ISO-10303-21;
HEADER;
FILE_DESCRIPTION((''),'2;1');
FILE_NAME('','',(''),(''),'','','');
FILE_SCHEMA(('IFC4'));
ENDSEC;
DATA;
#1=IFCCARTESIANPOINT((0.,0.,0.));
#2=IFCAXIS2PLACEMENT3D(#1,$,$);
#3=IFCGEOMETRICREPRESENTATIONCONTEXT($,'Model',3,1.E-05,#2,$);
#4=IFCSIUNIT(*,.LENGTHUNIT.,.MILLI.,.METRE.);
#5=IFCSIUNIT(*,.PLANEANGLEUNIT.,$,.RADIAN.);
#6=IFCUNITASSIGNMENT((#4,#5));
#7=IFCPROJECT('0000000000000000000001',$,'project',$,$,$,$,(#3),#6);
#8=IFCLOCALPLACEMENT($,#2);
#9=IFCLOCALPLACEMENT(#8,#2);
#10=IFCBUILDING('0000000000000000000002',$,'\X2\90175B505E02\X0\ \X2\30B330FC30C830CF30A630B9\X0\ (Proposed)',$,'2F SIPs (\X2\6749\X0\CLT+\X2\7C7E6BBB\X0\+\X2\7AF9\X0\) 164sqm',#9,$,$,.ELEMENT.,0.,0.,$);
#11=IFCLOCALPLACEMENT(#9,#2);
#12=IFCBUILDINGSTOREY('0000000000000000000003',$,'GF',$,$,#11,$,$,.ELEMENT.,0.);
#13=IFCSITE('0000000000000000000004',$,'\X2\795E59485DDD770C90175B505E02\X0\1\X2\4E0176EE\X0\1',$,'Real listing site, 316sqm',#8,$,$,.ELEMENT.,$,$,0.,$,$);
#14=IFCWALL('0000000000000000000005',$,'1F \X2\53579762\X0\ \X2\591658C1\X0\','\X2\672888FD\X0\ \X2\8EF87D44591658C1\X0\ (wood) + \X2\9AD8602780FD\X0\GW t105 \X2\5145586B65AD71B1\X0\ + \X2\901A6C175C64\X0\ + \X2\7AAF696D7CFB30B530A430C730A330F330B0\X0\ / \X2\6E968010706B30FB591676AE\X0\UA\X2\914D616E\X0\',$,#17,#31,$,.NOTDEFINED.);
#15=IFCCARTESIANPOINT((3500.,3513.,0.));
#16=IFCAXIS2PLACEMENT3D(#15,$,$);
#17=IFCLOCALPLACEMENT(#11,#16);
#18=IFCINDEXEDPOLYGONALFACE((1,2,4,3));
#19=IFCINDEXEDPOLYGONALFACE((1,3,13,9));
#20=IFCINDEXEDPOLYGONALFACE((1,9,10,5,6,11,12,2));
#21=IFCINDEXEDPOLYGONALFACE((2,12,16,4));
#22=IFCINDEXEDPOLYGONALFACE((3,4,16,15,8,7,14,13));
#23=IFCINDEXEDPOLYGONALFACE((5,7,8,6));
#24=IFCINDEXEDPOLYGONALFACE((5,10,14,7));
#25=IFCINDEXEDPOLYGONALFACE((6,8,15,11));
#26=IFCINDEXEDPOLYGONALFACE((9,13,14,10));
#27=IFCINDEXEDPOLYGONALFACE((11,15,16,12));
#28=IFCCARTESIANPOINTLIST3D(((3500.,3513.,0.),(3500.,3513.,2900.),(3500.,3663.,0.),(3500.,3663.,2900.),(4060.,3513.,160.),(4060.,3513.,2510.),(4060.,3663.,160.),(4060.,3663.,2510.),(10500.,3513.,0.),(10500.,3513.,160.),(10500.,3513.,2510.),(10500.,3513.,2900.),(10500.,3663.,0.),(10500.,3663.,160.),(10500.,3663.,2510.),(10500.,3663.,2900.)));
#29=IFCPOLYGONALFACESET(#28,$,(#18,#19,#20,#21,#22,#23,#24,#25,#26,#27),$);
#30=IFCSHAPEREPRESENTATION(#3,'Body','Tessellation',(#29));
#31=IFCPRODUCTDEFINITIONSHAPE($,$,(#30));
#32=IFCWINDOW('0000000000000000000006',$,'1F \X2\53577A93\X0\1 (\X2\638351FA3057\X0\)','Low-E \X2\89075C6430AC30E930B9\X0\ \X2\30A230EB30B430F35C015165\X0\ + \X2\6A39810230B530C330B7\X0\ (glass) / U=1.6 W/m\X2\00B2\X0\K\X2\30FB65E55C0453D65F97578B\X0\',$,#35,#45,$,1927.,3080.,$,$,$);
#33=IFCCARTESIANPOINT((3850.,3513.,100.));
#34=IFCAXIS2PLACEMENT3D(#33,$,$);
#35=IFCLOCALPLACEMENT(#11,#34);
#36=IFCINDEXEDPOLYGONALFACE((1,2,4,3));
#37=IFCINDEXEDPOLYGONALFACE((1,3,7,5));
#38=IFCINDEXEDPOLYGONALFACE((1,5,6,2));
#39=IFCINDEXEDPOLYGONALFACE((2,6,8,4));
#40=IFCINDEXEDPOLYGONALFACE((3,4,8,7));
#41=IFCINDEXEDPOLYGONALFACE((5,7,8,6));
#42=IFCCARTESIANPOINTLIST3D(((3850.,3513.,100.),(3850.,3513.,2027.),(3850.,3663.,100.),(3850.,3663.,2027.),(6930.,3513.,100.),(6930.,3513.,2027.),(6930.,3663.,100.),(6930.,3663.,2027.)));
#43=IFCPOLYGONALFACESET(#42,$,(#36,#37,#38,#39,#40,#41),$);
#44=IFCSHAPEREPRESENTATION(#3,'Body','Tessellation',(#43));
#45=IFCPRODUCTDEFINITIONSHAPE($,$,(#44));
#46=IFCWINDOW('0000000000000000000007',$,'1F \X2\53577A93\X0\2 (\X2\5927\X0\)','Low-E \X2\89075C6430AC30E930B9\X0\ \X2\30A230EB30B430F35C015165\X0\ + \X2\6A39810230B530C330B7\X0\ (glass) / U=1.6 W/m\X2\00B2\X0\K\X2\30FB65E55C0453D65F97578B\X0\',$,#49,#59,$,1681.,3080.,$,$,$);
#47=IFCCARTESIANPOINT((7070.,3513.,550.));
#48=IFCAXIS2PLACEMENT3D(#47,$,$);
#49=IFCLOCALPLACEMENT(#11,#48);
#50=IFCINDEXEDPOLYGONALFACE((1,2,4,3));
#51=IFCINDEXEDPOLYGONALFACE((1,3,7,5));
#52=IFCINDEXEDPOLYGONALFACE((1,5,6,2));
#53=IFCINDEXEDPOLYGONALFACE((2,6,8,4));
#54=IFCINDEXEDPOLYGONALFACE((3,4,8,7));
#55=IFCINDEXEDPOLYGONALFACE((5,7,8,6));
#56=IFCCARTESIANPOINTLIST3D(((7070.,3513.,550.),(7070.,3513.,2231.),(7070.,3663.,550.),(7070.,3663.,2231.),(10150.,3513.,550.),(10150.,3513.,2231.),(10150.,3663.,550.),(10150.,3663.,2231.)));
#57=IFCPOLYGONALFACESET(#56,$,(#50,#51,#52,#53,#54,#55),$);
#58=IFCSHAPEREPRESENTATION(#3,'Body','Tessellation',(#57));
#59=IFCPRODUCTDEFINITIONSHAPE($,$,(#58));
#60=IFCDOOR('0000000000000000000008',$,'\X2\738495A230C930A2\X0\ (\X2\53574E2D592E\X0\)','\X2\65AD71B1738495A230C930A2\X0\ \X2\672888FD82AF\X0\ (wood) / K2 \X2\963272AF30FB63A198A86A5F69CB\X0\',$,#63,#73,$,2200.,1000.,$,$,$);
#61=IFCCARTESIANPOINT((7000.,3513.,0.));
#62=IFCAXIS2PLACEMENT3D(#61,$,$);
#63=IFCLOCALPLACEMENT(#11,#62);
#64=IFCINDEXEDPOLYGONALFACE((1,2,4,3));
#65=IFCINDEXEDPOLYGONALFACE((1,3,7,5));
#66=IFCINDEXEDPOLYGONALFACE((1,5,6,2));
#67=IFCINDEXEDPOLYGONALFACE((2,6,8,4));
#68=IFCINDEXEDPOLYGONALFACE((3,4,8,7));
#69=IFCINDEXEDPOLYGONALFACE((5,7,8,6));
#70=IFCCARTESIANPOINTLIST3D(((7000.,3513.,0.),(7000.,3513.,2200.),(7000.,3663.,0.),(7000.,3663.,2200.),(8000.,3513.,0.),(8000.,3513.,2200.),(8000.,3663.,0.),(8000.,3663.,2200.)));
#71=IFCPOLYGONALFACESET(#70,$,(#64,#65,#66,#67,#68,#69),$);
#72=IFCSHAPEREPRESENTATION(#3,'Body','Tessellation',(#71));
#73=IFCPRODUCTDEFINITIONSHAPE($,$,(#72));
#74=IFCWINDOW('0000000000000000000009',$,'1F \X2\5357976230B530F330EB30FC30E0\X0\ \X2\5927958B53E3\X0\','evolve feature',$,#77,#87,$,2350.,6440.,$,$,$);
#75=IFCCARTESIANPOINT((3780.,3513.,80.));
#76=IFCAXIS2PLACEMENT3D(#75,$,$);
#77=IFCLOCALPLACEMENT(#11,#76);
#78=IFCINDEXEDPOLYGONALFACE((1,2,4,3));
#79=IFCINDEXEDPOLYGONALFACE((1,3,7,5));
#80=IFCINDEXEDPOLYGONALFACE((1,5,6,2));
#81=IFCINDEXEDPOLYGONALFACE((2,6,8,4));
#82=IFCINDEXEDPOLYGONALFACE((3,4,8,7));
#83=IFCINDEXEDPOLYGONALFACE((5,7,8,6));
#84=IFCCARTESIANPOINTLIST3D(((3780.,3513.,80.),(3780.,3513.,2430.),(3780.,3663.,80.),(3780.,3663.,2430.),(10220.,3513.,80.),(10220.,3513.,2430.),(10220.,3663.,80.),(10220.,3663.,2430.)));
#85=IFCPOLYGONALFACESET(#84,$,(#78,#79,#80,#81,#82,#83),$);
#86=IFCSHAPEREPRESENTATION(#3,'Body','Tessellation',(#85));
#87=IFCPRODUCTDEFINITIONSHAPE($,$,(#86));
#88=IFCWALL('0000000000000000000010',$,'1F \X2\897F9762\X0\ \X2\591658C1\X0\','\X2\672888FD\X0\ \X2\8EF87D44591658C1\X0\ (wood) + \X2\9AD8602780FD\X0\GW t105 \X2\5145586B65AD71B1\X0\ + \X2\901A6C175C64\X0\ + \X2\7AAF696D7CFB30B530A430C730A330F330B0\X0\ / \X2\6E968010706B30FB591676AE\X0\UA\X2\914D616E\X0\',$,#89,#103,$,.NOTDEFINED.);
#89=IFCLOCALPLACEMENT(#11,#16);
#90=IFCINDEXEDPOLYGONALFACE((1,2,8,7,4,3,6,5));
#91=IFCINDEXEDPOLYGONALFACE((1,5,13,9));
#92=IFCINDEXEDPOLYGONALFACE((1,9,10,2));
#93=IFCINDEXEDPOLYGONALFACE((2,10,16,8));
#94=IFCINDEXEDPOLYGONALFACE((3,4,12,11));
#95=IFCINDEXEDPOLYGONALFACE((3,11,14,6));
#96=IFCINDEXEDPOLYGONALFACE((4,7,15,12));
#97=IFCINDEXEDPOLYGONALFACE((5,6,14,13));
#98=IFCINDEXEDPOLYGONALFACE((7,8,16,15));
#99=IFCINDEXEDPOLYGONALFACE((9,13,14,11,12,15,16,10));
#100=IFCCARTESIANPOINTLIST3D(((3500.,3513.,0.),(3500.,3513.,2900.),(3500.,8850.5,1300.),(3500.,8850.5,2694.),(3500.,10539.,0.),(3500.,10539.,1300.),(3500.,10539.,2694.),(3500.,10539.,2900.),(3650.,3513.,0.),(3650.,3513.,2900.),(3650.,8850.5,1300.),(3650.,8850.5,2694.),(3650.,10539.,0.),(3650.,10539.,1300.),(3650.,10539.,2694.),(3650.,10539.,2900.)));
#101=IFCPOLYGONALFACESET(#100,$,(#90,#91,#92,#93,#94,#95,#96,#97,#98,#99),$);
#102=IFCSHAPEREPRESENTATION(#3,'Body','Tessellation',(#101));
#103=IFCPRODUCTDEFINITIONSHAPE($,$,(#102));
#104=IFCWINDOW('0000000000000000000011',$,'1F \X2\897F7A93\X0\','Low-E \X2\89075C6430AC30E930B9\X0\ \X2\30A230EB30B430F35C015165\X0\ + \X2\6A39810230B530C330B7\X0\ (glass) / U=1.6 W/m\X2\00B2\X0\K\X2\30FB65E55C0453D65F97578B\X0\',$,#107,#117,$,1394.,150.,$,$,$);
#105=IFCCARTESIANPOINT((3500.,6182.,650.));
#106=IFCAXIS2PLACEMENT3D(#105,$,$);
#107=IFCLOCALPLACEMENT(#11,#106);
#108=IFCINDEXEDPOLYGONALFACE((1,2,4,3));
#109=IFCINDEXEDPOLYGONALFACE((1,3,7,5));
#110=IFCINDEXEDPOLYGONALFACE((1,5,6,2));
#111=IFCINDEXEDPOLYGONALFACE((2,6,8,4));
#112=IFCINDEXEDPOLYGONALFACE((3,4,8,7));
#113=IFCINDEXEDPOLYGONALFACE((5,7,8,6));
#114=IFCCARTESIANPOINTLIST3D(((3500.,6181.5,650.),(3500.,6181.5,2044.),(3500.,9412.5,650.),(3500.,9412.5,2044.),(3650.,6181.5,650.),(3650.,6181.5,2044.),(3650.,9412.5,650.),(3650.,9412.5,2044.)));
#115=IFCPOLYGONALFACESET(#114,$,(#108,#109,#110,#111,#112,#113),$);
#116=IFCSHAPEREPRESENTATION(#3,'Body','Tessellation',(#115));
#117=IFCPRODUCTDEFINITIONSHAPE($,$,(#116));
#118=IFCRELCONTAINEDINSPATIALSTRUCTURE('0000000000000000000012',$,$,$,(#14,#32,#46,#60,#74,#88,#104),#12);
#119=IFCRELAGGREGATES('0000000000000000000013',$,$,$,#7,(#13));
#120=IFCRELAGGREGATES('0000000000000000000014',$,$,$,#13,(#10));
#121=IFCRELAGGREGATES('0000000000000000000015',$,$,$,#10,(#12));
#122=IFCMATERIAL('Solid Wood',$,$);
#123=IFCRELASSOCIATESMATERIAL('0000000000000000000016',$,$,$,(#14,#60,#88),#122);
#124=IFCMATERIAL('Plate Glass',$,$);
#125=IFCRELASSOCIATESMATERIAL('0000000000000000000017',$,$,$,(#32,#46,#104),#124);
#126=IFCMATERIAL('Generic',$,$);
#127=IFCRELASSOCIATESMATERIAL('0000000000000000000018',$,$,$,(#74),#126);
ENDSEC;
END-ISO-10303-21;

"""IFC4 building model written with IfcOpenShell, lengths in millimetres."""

from ifc_helpers import new_model, si_unit, frame, frame_2d, origin, place, context, project, spatial, rectangle, extrude, material, element, fill, save


model = new_model("IFC4")

# Units and contexts
model_context = context("Model", 3, precision=1e-05, world=origin())
ifc_project = project(units=[si_unit("LENGTHUNIT", "METRE", prefix="MILLI"), si_unit("PLANEANGLEUNIT", "RADIAN")], contexts=[model_context])

# Site, building, storey
site_placement = place(None, origin())
site = spatial("IfcSite", under=ifc_project, at=site_placement, Name="神奈川県逗子市1丁目1", ObjectType="Real listing site, 316sqm", CompositionType="ELEMENT", RefElevation=0.0)
building_placement = place(site_placement, origin())
building = spatial("IfcBuilding", under=site, at=building_placement, Name="逗子市 コートハウス (Proposed)", ObjectType="2F SIPs (杉CLT+籾殻+竹) 164sqm", CompositionType="ELEMENT", ElevationOfRefHeight=0.0, ElevationOfTerrain=0.0)
storey_placement = place(building_placement, origin())
storey = spatial("IfcBuildingStorey", under=building, at=storey_placement, Name="GF", CompositionType="ELEMENT", Elevation=0.0)

# Shared definitions
ifc_material_1 = material(Name="Solid Wood")
ifc_material_2 = material(Name="Generic")

# Wall, openings, windows, door
wall_1_placement = place(storey_placement, frame((3500.0, 3513.0, 0.0)))
wall_1 = element("IfcWall", 1, at=wall_1_placement, inside=storey, material=ifc_material_1, Name="1F 南面 外壁", Description="木製 軸組外壁 (wood) + 高性能GW t105 充填断熱 + 通気層 + 窯業系サイディング / 準耐火・外皮UA配慮", PredefinedType="NOTDEFINED", context=model_context, shape_type="SweptSolid", body=[
    extrude(rectangle(XDim=7000.0, YDim=150.0, at=frame_2d((3500.0, 75.0))), frame((3500.0, 3513.0, 0.0)), (0.0, 0.0, 1.0), 2900.0),
])
opening_1_placement = place(storey_placement, frame((3850.0, 3513.0, 100.0)))
opening_1 = element("IfcOpeningElement", 2, at=opening_1_placement, cuts=wall_1, PredefinedType="NOTDEFINED", context=model_context, shape_type="SweptSolid", body=[
    extrude(rectangle(XDim=3080.0, YDim=150.0, at=frame_2d((1540.0, 75.0))), frame((3850.0, 3513.0, 100.0)), (0.0, 0.0, 1.0), 1927.0),
])
opening_2_placement = place(storey_placement, frame((7070.0, 3513.0, 550.0)))
opening_2 = element("IfcOpeningElement", 3, at=opening_2_placement, cuts=wall_1, PredefinedType="NOTDEFINED", context=model_context, shape_type="SweptSolid", body=[
    extrude(rectangle(XDim=3080.0, YDim=150.0, at=frame_2d((1540.0, 75.0))), frame((7070.0, 3513.0, 550.0)), (0.0, 0.0, 1.0), 1681.0),
])
opening_3_placement = place(storey_placement, frame((7000.0, 3513.0, 0.0)))
opening_3 = element("IfcOpeningElement", 4, at=opening_3_placement, cuts=wall_1, PredefinedType="NOTDEFINED", context=model_context, shape_type="SweptSolid", body=[
    extrude(rectangle(XDim=1000.0, YDim=150.0, at=frame_2d((500.0, 75.0))), frame((7000.0, 3513.0, 0.0)), (0.0, 0.0, 1.0), 2200.0),
])
opening_4_placement = place(storey_placement, frame((3780.0, 3513.0, 80.0)))
opening_4 = element("IfcOpeningElement", 5, at=opening_4_placement, cuts=wall_1, PredefinedType="NOTDEFINED", context=model_context, shape_type="SweptSolid", body=[
    extrude(rectangle(XDim=6440.0, YDim=150.0, at=frame_2d((3220.0, 75.0))), frame((3780.0, 3513.0, 80.0)), (0.0, 0.0, 1.0), 2350.0),
])
ifc_material_3 = material(Name="Plate Glass")
window_1_placement = place(storey_placement, frame((3850.0, 3513.0, 100.0)))
window_1 = element("IfcWindow", 6, at=window_1_placement, inside=storey, material=ifc_material_3, Name="1F 南窓1 (掃出し)", Description="Low-E 複層ガラス アルゴン封入 + 樹脂サッシ (glass) / U=1.6 W/m²K・日射取得型", OverallHeight=1927.0, OverallWidth=3080.0, context=model_context, shape_type="SweptSolid", body=[
    extrude(rectangle(XDim=3080.0, YDim=150.0, at=frame_2d((1540.0, 75.0))), frame((3850.0, 3513.0, 100.0)), (0.0, 0.0, 1.0), 1927.0),
])
fill(opening_1, window_1)
window_2_placement = place(storey_placement, frame((7070.0, 3513.0, 550.0)))
window_2 = element("IfcWindow", 7, at=window_2_placement, inside=storey, material=ifc_material_3, Name="1F 南窓2 (大)", Description="Low-E 複層ガラス アルゴン封入 + 樹脂サッシ (glass) / U=1.6 W/m²K・日射取得型", OverallHeight=1681.0, OverallWidth=3080.0, context=model_context, shape_type="SweptSolid", body=[
    extrude(rectangle(XDim=3080.0, YDim=150.0, at=frame_2d((1540.0, 75.0))), frame((7070.0, 3513.0, 550.0)), (0.0, 0.0, 1.0), 1681.0),
])
fill(opening_2, window_2)
door_placement = place(storey_placement, frame((7000.0, 3513.0, 0.0)))
door = element("IfcDoor", 8, at=door_placement, inside=storey, material=ifc_material_1, Name="玄関ドア (南中央)", Description="断熱玄関ドア 木製芯 (wood) / K2 防犯・採風機構", OverallHeight=2200.0, OverallWidth=1000.0, context=model_context, shape_type="SweptSolid", body=[
    extrude(rectangle(XDim=1000.0, YDim=150.0, at=frame_2d((500.0, 75.0))), frame((7000.0, 3513.0, 0.0)), (0.0, 0.0, 1.0), 2200.0),
])
fill(opening_3, door)
window_3_placement = place(storey_placement, frame((3780.0, 3513.0, 80.0)))
window_3 = element("IfcWindow", 9, at=window_3_placement, inside=storey, material=ifc_material_2, Name="1F 南面サンルーム 大開口", Description="evolve feature", OverallHeight=2350.0, OverallWidth=6440.0, context=model_context, shape_type="SweptSolid", body=[
    extrude(rectangle(XDim=6440.0, YDim=150.0, at=frame_2d((3220.0, 75.0))), frame((3780.0, 3513.0, 80.0)), (0.0, 0.0, 1.0), 2350.0),
])
fill(opening_4, window_3)

# Wall, opening, window
wall_2_placement = place(storey_placement, frame((3500.0, 3513.0, 0.0)))
wall_2 = element("IfcWall", 10, at=wall_2_placement, inside=storey, material=ifc_material_1, Name="1F 西面 外壁", Description="木製 軸組外壁 (wood) + 高性能GW t105 充填断熱 + 通気層 + 窯業系サイディング / 準耐火・外皮UA配慮", PredefinedType="NOTDEFINED", context=model_context, shape_type="SweptSolid", body=[
    extrude(rectangle(XDim=150.0, YDim=7026.0, at=frame_2d((75.0, 3513.0))), frame((3500.0, 3513.0, 0.0)), (0.0, 0.0, 1.0), 2900.0),
])
opening_5_placement = place(storey_placement, frame((3500.0, 6182.0, 650.0)))
opening_5 = element("IfcOpeningElement", 11, at=opening_5_placement, cuts=wall_2, PredefinedType="NOTDEFINED", context=model_context, shape_type="SweptSolid", body=[
    extrude(rectangle(XDim=150.0, YDim=3231.0, at=frame_2d((75.0, 1615.0))), frame((3500.0, 6182.0, 650.0)), (0.0, 0.0, 1.0), 1394.0),
])
window_4_placement = place(storey_placement, frame((3500.0, 6182.0, 650.0)))
window_4 = element("IfcWindow", 12, at=window_4_placement, inside=storey, material=ifc_material_3, Name="1F 西窓", Description="Low-E 複層ガラス アルゴン封入 + 樹脂サッシ (glass) / U=1.6 W/m²K・日射取得型", OverallHeight=1394.0, OverallWidth=150.0, context=model_context, shape_type="SweptSolid", body=[
    extrude(rectangle(XDim=150.0, YDim=3231.0, at=frame_2d((75.0, 1615.0))), frame((3500.0, 6182.0, 650.0)), (0.0, 0.0, 1.0), 1394.0),
])
fill(opening_5, window_4)

save(model, "model.ifc")
